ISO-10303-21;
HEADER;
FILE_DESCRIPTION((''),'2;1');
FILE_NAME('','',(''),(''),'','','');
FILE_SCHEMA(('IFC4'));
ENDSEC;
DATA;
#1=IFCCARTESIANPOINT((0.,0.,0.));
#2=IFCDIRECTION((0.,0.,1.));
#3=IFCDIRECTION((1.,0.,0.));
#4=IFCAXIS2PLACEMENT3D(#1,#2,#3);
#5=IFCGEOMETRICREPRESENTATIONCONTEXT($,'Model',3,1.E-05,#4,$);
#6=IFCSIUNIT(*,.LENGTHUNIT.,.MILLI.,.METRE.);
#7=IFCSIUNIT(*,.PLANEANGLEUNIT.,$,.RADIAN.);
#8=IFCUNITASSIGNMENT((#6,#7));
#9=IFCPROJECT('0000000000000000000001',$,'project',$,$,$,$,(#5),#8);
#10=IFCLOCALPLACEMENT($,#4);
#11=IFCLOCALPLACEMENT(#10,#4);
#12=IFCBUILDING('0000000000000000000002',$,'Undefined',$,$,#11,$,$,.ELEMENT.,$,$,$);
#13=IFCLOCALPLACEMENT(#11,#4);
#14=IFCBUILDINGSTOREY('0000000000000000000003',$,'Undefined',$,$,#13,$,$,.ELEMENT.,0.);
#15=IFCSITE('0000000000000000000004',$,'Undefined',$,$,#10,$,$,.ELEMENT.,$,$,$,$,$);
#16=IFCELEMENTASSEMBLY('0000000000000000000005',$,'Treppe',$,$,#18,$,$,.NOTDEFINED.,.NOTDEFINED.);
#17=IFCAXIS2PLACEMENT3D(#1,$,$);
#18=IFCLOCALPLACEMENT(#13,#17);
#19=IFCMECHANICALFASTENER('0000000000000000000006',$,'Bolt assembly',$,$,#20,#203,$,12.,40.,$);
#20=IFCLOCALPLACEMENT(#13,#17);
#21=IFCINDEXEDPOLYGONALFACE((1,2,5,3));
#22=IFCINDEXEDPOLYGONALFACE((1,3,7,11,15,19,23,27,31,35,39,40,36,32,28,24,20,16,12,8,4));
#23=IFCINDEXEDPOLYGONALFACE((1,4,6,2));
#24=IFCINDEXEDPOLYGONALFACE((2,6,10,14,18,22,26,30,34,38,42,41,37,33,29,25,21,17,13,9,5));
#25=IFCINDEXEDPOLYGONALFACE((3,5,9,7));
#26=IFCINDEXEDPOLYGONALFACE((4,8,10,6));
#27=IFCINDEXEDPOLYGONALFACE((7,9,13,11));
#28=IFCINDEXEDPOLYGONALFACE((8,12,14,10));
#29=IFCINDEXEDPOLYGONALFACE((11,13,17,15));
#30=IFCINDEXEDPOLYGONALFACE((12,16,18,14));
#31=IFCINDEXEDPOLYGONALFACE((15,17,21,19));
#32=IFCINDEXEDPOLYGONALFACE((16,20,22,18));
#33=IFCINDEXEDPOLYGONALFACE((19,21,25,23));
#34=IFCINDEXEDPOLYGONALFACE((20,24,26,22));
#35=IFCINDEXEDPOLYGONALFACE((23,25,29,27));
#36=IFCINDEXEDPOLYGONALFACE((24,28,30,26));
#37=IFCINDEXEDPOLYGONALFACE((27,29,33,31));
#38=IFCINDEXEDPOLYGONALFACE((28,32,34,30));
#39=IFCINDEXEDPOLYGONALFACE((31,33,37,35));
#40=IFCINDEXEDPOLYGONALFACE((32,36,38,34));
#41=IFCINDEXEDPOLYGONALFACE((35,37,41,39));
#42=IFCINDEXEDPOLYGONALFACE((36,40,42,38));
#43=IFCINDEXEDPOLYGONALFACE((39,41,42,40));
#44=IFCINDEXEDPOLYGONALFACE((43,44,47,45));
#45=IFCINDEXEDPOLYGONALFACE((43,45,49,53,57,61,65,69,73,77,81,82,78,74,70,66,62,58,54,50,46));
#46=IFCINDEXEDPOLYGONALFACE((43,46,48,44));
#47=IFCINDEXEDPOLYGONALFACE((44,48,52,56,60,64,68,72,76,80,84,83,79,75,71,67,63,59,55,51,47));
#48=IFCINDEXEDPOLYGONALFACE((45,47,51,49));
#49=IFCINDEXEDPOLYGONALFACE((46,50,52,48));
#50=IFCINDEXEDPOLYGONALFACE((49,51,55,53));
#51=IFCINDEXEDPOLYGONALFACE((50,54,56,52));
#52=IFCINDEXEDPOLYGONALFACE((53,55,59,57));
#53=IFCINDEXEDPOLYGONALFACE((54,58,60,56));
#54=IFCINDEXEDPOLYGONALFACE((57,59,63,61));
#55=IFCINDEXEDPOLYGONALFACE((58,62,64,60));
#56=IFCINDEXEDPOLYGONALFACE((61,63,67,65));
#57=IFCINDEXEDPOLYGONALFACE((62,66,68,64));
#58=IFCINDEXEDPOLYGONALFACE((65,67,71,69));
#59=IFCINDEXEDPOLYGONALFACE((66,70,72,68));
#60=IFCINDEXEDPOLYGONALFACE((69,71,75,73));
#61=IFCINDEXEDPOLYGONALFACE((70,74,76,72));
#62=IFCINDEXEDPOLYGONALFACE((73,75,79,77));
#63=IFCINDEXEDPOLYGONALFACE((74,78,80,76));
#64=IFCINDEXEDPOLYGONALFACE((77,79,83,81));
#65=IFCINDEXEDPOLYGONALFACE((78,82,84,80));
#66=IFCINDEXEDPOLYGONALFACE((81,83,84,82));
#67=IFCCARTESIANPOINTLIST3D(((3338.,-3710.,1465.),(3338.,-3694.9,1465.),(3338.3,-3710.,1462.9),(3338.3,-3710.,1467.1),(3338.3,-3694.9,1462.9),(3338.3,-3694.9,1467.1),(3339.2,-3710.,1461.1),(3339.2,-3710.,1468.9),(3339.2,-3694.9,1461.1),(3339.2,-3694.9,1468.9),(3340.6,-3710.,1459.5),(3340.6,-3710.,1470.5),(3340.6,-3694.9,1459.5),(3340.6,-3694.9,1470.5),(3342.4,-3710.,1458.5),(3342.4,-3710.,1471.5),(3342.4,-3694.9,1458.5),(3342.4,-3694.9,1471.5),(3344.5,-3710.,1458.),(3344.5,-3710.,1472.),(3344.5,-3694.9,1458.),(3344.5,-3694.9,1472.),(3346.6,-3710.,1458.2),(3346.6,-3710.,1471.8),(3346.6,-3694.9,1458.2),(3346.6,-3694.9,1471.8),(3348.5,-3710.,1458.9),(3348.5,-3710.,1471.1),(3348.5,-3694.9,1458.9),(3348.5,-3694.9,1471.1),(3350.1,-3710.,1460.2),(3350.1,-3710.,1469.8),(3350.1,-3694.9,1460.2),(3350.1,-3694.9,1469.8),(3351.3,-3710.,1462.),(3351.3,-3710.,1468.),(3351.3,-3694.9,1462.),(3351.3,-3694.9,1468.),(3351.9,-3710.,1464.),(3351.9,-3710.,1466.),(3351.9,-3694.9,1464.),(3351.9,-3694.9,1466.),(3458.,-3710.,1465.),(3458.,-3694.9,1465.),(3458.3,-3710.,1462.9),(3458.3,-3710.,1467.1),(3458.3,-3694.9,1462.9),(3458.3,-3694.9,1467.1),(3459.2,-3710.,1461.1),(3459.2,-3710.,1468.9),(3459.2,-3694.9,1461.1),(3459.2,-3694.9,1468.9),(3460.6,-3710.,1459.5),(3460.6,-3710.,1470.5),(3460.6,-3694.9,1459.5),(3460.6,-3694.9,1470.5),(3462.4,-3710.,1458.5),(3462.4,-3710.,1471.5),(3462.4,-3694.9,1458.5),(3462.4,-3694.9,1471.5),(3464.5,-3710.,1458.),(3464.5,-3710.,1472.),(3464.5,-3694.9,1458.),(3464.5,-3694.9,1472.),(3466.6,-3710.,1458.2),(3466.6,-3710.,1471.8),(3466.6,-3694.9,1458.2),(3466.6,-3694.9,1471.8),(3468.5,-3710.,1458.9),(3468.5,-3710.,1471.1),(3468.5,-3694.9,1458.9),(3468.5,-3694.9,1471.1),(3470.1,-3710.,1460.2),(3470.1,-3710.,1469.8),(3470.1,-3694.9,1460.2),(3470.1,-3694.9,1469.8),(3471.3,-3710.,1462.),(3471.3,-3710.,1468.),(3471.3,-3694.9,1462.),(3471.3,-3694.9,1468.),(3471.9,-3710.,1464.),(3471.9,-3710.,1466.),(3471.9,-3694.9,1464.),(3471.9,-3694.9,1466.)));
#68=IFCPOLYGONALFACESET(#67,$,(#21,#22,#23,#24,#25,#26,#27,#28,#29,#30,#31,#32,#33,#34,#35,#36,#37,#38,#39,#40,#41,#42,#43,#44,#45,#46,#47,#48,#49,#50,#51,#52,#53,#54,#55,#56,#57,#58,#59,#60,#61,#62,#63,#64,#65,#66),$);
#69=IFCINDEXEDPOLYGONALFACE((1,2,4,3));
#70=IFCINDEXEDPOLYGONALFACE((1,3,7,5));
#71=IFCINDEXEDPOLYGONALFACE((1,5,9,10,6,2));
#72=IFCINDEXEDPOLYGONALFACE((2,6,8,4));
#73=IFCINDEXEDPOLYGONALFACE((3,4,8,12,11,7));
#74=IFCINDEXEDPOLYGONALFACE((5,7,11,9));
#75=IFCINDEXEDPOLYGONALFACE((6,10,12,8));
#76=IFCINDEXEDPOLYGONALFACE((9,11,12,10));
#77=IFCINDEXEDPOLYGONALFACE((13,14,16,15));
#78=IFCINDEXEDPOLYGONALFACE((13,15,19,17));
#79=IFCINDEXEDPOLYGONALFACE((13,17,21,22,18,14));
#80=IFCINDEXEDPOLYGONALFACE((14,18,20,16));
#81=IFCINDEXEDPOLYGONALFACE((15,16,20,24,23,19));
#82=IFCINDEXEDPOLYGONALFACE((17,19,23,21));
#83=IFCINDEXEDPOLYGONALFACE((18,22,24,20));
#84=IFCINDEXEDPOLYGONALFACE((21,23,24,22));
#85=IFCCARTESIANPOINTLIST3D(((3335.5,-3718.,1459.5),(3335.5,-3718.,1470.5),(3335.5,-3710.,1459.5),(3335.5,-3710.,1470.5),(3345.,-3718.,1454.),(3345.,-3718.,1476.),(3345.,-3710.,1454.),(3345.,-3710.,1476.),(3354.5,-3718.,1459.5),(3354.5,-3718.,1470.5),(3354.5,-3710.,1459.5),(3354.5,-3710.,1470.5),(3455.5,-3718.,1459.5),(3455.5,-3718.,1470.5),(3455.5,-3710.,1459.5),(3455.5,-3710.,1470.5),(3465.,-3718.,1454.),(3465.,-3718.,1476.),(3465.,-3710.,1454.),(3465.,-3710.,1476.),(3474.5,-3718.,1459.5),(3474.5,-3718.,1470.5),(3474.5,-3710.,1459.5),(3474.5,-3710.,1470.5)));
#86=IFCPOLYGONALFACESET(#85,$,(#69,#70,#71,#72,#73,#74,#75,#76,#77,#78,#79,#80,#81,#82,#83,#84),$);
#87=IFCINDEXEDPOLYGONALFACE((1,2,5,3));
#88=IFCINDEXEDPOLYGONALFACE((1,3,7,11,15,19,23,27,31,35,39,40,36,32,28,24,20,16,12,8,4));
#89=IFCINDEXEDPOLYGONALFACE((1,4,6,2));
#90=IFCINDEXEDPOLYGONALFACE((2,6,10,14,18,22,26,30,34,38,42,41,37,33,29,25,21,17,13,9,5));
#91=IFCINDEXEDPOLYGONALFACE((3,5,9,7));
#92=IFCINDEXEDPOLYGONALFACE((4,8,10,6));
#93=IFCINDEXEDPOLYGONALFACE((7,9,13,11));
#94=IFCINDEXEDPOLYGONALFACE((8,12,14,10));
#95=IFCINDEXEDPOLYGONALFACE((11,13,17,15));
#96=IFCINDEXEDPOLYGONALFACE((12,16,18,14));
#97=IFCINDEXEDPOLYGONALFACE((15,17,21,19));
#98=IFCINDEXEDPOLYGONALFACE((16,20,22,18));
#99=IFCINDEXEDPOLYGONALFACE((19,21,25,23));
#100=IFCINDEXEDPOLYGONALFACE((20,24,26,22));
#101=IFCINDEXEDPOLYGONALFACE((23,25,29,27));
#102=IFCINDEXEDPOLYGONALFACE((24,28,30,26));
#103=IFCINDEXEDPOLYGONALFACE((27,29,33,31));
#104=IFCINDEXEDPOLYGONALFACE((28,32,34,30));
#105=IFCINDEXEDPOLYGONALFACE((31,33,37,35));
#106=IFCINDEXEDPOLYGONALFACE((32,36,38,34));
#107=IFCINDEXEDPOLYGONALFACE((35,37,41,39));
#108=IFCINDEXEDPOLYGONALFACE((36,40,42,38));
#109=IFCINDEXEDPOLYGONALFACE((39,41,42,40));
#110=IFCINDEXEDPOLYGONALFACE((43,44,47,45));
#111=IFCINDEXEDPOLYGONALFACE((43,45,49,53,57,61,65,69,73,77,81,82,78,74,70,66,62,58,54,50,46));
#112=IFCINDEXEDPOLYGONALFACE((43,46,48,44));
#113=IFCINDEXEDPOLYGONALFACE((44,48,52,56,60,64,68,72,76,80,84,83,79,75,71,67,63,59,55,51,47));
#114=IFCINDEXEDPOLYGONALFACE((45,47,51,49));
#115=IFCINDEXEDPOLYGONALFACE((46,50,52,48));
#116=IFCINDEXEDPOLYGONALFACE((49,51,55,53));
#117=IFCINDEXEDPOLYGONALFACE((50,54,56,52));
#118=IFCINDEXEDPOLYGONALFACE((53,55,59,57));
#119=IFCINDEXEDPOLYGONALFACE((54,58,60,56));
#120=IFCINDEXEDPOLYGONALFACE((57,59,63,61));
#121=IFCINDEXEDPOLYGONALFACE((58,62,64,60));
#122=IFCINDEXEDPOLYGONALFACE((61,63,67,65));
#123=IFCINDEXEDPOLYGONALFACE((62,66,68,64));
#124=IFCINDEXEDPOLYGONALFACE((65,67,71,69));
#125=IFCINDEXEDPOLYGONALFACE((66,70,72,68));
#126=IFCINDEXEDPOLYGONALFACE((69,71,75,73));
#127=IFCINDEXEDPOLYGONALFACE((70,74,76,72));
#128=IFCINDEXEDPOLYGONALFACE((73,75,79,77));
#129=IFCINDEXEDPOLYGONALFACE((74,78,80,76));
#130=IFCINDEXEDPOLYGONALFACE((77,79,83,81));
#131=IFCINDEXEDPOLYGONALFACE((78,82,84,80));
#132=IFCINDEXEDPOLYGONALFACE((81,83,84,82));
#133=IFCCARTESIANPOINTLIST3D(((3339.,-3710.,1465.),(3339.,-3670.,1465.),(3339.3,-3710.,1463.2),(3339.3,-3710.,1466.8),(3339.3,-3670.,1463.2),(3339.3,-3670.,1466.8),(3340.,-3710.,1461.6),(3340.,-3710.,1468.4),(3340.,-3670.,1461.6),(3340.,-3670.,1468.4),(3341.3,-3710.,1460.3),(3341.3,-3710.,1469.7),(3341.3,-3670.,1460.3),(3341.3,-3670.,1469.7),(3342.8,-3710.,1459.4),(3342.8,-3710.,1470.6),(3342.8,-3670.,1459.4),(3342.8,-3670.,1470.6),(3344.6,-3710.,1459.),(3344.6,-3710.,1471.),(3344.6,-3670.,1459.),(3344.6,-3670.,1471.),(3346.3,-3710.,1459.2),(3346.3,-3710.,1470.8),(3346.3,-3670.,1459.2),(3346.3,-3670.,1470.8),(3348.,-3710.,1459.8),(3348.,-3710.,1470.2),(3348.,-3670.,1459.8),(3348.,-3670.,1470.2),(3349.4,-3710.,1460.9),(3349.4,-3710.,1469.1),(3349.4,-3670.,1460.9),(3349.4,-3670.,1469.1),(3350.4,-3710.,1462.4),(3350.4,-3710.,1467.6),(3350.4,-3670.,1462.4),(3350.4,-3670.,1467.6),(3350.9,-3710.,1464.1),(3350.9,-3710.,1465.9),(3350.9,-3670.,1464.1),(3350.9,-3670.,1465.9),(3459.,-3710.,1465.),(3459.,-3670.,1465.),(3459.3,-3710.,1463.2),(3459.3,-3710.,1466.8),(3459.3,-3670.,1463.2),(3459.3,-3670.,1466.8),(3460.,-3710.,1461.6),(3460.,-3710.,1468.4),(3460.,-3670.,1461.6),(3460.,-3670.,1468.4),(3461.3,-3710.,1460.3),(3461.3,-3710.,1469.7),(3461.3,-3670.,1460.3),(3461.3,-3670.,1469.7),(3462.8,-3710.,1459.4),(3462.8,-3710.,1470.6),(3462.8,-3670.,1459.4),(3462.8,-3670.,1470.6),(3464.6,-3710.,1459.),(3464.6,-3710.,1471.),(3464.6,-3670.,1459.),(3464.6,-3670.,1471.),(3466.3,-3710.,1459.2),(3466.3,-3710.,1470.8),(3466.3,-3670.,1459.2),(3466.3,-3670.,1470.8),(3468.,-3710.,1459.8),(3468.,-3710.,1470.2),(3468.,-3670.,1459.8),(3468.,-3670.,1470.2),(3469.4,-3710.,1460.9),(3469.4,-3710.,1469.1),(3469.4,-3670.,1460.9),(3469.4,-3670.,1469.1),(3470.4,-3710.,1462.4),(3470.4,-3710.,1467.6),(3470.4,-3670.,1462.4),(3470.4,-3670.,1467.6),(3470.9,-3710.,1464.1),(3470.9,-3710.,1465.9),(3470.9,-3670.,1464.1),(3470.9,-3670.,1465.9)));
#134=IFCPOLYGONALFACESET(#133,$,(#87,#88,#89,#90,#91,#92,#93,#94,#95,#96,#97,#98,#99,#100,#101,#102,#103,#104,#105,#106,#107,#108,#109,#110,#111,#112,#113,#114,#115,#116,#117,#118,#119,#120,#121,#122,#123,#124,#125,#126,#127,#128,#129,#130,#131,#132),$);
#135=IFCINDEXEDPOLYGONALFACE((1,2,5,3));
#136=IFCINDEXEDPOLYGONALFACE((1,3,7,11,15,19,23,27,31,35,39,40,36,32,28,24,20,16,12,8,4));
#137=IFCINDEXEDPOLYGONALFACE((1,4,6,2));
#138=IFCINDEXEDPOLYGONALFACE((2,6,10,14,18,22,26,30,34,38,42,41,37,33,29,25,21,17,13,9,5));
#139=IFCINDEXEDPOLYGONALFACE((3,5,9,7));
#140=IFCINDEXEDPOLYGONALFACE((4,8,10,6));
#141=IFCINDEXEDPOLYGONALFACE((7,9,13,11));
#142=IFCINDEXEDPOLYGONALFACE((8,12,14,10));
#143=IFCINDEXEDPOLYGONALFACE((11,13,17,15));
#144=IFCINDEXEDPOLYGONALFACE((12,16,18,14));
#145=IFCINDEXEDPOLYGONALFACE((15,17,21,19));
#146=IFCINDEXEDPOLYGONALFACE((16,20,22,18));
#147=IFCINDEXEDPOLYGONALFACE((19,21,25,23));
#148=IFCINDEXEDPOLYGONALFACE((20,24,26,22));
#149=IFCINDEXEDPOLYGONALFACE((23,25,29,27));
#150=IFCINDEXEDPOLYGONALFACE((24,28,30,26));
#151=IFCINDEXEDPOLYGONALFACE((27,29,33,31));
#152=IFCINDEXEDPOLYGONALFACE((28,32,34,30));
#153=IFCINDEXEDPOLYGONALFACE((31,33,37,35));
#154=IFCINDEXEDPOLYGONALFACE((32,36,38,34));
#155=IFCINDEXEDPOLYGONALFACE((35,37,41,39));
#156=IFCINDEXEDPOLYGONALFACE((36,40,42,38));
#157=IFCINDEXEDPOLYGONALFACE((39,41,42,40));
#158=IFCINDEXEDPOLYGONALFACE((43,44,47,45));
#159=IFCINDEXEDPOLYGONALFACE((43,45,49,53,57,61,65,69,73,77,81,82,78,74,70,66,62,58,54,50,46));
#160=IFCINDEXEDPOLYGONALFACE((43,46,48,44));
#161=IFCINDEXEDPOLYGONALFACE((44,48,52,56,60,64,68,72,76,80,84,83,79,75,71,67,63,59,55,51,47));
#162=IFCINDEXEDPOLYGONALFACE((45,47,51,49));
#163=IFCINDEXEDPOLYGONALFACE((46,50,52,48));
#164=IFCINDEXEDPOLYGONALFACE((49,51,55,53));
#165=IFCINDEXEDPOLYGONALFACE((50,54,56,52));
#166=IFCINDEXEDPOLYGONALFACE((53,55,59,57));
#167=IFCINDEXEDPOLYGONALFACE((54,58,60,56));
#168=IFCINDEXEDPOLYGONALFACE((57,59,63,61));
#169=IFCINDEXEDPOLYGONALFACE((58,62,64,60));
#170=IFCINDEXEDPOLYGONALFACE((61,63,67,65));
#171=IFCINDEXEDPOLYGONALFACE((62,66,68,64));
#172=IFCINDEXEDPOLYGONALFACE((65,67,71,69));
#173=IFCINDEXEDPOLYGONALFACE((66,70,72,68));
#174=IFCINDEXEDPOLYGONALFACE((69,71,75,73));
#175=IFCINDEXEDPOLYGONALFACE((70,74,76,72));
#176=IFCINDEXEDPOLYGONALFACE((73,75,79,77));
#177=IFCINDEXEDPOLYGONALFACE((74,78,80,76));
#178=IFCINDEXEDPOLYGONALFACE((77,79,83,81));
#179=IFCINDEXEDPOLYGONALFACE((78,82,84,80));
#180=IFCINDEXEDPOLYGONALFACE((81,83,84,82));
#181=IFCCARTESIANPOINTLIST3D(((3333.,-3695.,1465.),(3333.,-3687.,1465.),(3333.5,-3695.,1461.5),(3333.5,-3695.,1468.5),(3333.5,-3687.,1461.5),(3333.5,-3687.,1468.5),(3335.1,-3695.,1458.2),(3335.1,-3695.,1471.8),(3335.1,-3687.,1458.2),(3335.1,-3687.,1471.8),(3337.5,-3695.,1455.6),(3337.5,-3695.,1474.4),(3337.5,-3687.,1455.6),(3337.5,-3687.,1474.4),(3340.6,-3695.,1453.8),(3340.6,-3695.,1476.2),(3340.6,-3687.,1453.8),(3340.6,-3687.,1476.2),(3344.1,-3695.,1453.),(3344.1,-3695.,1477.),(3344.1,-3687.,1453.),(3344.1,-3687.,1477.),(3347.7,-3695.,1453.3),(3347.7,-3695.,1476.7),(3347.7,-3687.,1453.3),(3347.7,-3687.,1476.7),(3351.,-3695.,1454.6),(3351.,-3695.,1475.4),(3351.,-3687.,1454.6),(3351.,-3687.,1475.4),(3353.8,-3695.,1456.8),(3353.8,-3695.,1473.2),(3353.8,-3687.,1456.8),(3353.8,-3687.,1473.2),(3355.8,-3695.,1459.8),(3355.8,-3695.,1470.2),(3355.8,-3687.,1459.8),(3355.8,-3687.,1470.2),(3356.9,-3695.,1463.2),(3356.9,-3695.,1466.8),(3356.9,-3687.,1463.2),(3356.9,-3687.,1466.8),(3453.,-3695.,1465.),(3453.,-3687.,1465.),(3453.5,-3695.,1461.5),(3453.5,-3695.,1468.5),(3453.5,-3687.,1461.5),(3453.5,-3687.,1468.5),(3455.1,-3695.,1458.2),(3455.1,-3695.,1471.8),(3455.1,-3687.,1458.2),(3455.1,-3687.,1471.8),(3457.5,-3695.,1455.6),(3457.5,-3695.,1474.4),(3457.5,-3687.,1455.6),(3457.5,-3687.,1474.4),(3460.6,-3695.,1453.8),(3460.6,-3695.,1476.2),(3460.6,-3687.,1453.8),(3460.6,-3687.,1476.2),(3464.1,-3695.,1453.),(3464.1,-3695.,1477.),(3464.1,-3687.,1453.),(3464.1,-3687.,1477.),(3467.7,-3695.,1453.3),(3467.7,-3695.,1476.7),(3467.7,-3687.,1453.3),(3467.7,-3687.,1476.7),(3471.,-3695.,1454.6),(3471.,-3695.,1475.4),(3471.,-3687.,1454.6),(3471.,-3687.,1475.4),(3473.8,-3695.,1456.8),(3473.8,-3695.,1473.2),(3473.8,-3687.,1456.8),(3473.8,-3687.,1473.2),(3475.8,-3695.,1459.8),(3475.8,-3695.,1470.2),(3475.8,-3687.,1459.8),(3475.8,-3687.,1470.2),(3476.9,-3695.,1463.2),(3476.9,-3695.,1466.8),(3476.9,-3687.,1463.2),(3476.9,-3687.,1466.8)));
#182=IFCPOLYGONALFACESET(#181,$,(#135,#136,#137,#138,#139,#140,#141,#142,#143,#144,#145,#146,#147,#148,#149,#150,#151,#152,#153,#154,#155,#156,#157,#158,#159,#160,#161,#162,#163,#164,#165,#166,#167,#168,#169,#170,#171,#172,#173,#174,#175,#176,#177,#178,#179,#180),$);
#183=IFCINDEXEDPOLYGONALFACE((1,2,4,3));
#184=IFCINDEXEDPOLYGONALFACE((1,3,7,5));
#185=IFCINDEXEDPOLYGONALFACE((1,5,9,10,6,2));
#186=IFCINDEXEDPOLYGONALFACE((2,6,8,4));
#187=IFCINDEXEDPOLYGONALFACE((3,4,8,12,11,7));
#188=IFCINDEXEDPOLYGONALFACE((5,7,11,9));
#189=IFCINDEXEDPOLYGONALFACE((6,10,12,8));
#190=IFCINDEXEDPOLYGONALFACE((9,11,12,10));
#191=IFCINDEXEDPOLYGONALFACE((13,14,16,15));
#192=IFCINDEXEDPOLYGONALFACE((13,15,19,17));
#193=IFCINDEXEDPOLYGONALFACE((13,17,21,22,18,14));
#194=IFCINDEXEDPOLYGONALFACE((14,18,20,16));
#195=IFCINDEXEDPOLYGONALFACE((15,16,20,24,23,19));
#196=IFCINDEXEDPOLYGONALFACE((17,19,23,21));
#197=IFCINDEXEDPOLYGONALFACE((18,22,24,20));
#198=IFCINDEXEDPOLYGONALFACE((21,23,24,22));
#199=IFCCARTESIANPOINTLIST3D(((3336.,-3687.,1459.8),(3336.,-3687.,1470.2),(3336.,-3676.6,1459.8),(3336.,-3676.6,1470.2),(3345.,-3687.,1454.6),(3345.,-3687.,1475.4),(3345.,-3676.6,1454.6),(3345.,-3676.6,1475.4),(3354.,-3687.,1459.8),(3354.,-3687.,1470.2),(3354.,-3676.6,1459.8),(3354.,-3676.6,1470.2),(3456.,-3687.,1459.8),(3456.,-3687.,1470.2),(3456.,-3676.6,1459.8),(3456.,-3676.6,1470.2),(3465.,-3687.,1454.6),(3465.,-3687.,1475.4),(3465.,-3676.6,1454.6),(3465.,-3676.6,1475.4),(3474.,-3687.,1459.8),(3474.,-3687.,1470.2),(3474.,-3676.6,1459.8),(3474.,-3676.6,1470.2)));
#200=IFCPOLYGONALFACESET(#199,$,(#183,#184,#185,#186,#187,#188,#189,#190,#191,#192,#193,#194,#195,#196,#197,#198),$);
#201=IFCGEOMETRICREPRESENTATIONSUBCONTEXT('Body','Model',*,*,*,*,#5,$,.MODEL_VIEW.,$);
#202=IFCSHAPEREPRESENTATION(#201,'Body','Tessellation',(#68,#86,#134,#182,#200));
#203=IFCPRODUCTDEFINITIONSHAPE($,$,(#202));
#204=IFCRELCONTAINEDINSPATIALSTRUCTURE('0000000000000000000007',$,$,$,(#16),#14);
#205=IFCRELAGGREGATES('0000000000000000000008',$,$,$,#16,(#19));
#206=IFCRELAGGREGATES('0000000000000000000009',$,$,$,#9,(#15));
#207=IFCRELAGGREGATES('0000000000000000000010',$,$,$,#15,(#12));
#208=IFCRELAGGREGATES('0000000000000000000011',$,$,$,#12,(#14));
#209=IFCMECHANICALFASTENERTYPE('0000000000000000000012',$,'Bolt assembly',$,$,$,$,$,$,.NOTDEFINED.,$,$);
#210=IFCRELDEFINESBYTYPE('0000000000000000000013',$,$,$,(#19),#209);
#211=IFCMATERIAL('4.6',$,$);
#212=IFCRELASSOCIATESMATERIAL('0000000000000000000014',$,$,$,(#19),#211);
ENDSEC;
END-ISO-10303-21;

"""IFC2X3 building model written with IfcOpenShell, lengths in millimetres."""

from ifc_helpers import new_model, si_unit, frame, origin_with_axes, origin_2d_with_axis, place, context, subcontext, project, spatial, polyline, circle, outline, extrude, source, transform, mapped, material, type_object, element, aggregate, save


model = new_model("IFC2X3")

# Units and contexts
model_context = context("Model", 3, precision=1e-05, world=origin_with_axes())
body_context = subcontext(model_context, "Body", "Model", "MODEL_VIEW")
ifc_project = project(units=[si_unit("LENGTHUNIT", "METRE", prefix="MILLI"), si_unit("PLANEANGLEUNIT", "RADIAN")], contexts=[model_context])

# Site, building, storey
site_placement = place(None, origin_with_axes())
site = spatial("IfcSite", under=ifc_project, at=site_placement, Name="Undefined", CompositionType="ELEMENT")
building_placement = place(site_placement, origin_with_axes())
building = spatial("IfcBuilding", under=site, at=building_placement, Name="Undefined", CompositionType="ELEMENT")
storey_placement = place(building_placement, origin_with_axes())
storey = spatial("IfcBuildingStorey", under=building, at=storey_placement, Name="Undefined", CompositionType="ELEMENT", Elevation=0.0)

# Element assembly, mechanical fastener
assembly_1_placement = place(storey_placement, origin_with_axes())
assembly_1 = element("IfcElementAssembly", 1, at=assembly_1_placement, inside=storey, Name="Treppe", AssemblyPlace="NOTDEFINED", PredefinedType="NOTDEFINED")
ifc_material_1 = material(Name="4.6")
mechanical_fastener_type = type_object("IfcMechanicalFastenerType", Name="Bolt assembly")
shared_shape_1 = source(origin_with_axes(), body_context, "Body", "SweptSolid", [
    extrude(circle(Radius=7.0, at=origin_2d_with_axis()), frame((0.0, 0.0, 0.0), z_axis=(0.0, 1.0, 0.0), x_axis=(1.0, 0.0, 0.0)), (0.0, 0.0, 1.0), 15.1),
    extrude(outline(polyline([(9.5, -5.5), (9.5, 5.5), (0.0, 11.0), (-9.5, 5.5), (-9.5, -5.5), (0.0, -11.0), (9.5, -5.5)])), frame((0.0, -8.0, 0.0), z_axis=(0.0, 1.0, 0.0), x_axis=(1.0, 0.0, 0.0)), (0.0, 0.0, 1.0), 8.0),
    extrude(circle(Radius=6.0, at=origin_2d_with_axis()), frame((0.0, 0.0, 0.0), z_axis=(0.0, 1.0, 0.0), x_axis=(1.0, 0.0, 0.0)), (0.0, 0.0, 1.0), 40.0),
    extrude(circle(Radius=12.0, at=origin_2d_with_axis()), frame((0.0, 15.0, 0.0), z_axis=(0.0, 1.0, 0.0), x_axis=(1.0, 0.0, 0.0)), (0.0, 0.0, 1.0), 8.0),
    extrude(outline(polyline([(9.0, -5.2), (9.0, 5.2), (0.0, 10.4), (-9.0, 5.2), (-9.0, -5.2), (0.0, -10.4), (9.0, -5.2)])), frame((0.0, 23.0, 0.0), z_axis=(0.0, 1.0, 0.0), x_axis=(1.0, 0.0, 0.0)), (0.0, 0.0, 1.0), 10.4),
])
mechanical_fastener_1_placement = place(assembly_1_placement, frame((3465.0, -3710.0, 1465.0), z_axis=(0.0, 0.0, -1.0), x_axis=(-1.0, 0.0, 0.0)))
mechanical_fastener_1 = element("IfcMechanicalFastener", 2, at=mechanical_fastener_1_placement, type_object=mechanical_fastener_type, material=ifc_material_1, Name="Bolt assembly", NominalDiameter=12.0, NominalLength=40.0, context=body_context, shape_type="MappedRepresentation", body=[
    mapped(shared_shape_1, transform((0.0, 0.0, 0.0))),
    mapped(shared_shape_1, transform((120.0, 0.0, 0.0))),
])
aggregate(assembly_1, [mechanical_fastener_1])

save(model, "model.ifc")
